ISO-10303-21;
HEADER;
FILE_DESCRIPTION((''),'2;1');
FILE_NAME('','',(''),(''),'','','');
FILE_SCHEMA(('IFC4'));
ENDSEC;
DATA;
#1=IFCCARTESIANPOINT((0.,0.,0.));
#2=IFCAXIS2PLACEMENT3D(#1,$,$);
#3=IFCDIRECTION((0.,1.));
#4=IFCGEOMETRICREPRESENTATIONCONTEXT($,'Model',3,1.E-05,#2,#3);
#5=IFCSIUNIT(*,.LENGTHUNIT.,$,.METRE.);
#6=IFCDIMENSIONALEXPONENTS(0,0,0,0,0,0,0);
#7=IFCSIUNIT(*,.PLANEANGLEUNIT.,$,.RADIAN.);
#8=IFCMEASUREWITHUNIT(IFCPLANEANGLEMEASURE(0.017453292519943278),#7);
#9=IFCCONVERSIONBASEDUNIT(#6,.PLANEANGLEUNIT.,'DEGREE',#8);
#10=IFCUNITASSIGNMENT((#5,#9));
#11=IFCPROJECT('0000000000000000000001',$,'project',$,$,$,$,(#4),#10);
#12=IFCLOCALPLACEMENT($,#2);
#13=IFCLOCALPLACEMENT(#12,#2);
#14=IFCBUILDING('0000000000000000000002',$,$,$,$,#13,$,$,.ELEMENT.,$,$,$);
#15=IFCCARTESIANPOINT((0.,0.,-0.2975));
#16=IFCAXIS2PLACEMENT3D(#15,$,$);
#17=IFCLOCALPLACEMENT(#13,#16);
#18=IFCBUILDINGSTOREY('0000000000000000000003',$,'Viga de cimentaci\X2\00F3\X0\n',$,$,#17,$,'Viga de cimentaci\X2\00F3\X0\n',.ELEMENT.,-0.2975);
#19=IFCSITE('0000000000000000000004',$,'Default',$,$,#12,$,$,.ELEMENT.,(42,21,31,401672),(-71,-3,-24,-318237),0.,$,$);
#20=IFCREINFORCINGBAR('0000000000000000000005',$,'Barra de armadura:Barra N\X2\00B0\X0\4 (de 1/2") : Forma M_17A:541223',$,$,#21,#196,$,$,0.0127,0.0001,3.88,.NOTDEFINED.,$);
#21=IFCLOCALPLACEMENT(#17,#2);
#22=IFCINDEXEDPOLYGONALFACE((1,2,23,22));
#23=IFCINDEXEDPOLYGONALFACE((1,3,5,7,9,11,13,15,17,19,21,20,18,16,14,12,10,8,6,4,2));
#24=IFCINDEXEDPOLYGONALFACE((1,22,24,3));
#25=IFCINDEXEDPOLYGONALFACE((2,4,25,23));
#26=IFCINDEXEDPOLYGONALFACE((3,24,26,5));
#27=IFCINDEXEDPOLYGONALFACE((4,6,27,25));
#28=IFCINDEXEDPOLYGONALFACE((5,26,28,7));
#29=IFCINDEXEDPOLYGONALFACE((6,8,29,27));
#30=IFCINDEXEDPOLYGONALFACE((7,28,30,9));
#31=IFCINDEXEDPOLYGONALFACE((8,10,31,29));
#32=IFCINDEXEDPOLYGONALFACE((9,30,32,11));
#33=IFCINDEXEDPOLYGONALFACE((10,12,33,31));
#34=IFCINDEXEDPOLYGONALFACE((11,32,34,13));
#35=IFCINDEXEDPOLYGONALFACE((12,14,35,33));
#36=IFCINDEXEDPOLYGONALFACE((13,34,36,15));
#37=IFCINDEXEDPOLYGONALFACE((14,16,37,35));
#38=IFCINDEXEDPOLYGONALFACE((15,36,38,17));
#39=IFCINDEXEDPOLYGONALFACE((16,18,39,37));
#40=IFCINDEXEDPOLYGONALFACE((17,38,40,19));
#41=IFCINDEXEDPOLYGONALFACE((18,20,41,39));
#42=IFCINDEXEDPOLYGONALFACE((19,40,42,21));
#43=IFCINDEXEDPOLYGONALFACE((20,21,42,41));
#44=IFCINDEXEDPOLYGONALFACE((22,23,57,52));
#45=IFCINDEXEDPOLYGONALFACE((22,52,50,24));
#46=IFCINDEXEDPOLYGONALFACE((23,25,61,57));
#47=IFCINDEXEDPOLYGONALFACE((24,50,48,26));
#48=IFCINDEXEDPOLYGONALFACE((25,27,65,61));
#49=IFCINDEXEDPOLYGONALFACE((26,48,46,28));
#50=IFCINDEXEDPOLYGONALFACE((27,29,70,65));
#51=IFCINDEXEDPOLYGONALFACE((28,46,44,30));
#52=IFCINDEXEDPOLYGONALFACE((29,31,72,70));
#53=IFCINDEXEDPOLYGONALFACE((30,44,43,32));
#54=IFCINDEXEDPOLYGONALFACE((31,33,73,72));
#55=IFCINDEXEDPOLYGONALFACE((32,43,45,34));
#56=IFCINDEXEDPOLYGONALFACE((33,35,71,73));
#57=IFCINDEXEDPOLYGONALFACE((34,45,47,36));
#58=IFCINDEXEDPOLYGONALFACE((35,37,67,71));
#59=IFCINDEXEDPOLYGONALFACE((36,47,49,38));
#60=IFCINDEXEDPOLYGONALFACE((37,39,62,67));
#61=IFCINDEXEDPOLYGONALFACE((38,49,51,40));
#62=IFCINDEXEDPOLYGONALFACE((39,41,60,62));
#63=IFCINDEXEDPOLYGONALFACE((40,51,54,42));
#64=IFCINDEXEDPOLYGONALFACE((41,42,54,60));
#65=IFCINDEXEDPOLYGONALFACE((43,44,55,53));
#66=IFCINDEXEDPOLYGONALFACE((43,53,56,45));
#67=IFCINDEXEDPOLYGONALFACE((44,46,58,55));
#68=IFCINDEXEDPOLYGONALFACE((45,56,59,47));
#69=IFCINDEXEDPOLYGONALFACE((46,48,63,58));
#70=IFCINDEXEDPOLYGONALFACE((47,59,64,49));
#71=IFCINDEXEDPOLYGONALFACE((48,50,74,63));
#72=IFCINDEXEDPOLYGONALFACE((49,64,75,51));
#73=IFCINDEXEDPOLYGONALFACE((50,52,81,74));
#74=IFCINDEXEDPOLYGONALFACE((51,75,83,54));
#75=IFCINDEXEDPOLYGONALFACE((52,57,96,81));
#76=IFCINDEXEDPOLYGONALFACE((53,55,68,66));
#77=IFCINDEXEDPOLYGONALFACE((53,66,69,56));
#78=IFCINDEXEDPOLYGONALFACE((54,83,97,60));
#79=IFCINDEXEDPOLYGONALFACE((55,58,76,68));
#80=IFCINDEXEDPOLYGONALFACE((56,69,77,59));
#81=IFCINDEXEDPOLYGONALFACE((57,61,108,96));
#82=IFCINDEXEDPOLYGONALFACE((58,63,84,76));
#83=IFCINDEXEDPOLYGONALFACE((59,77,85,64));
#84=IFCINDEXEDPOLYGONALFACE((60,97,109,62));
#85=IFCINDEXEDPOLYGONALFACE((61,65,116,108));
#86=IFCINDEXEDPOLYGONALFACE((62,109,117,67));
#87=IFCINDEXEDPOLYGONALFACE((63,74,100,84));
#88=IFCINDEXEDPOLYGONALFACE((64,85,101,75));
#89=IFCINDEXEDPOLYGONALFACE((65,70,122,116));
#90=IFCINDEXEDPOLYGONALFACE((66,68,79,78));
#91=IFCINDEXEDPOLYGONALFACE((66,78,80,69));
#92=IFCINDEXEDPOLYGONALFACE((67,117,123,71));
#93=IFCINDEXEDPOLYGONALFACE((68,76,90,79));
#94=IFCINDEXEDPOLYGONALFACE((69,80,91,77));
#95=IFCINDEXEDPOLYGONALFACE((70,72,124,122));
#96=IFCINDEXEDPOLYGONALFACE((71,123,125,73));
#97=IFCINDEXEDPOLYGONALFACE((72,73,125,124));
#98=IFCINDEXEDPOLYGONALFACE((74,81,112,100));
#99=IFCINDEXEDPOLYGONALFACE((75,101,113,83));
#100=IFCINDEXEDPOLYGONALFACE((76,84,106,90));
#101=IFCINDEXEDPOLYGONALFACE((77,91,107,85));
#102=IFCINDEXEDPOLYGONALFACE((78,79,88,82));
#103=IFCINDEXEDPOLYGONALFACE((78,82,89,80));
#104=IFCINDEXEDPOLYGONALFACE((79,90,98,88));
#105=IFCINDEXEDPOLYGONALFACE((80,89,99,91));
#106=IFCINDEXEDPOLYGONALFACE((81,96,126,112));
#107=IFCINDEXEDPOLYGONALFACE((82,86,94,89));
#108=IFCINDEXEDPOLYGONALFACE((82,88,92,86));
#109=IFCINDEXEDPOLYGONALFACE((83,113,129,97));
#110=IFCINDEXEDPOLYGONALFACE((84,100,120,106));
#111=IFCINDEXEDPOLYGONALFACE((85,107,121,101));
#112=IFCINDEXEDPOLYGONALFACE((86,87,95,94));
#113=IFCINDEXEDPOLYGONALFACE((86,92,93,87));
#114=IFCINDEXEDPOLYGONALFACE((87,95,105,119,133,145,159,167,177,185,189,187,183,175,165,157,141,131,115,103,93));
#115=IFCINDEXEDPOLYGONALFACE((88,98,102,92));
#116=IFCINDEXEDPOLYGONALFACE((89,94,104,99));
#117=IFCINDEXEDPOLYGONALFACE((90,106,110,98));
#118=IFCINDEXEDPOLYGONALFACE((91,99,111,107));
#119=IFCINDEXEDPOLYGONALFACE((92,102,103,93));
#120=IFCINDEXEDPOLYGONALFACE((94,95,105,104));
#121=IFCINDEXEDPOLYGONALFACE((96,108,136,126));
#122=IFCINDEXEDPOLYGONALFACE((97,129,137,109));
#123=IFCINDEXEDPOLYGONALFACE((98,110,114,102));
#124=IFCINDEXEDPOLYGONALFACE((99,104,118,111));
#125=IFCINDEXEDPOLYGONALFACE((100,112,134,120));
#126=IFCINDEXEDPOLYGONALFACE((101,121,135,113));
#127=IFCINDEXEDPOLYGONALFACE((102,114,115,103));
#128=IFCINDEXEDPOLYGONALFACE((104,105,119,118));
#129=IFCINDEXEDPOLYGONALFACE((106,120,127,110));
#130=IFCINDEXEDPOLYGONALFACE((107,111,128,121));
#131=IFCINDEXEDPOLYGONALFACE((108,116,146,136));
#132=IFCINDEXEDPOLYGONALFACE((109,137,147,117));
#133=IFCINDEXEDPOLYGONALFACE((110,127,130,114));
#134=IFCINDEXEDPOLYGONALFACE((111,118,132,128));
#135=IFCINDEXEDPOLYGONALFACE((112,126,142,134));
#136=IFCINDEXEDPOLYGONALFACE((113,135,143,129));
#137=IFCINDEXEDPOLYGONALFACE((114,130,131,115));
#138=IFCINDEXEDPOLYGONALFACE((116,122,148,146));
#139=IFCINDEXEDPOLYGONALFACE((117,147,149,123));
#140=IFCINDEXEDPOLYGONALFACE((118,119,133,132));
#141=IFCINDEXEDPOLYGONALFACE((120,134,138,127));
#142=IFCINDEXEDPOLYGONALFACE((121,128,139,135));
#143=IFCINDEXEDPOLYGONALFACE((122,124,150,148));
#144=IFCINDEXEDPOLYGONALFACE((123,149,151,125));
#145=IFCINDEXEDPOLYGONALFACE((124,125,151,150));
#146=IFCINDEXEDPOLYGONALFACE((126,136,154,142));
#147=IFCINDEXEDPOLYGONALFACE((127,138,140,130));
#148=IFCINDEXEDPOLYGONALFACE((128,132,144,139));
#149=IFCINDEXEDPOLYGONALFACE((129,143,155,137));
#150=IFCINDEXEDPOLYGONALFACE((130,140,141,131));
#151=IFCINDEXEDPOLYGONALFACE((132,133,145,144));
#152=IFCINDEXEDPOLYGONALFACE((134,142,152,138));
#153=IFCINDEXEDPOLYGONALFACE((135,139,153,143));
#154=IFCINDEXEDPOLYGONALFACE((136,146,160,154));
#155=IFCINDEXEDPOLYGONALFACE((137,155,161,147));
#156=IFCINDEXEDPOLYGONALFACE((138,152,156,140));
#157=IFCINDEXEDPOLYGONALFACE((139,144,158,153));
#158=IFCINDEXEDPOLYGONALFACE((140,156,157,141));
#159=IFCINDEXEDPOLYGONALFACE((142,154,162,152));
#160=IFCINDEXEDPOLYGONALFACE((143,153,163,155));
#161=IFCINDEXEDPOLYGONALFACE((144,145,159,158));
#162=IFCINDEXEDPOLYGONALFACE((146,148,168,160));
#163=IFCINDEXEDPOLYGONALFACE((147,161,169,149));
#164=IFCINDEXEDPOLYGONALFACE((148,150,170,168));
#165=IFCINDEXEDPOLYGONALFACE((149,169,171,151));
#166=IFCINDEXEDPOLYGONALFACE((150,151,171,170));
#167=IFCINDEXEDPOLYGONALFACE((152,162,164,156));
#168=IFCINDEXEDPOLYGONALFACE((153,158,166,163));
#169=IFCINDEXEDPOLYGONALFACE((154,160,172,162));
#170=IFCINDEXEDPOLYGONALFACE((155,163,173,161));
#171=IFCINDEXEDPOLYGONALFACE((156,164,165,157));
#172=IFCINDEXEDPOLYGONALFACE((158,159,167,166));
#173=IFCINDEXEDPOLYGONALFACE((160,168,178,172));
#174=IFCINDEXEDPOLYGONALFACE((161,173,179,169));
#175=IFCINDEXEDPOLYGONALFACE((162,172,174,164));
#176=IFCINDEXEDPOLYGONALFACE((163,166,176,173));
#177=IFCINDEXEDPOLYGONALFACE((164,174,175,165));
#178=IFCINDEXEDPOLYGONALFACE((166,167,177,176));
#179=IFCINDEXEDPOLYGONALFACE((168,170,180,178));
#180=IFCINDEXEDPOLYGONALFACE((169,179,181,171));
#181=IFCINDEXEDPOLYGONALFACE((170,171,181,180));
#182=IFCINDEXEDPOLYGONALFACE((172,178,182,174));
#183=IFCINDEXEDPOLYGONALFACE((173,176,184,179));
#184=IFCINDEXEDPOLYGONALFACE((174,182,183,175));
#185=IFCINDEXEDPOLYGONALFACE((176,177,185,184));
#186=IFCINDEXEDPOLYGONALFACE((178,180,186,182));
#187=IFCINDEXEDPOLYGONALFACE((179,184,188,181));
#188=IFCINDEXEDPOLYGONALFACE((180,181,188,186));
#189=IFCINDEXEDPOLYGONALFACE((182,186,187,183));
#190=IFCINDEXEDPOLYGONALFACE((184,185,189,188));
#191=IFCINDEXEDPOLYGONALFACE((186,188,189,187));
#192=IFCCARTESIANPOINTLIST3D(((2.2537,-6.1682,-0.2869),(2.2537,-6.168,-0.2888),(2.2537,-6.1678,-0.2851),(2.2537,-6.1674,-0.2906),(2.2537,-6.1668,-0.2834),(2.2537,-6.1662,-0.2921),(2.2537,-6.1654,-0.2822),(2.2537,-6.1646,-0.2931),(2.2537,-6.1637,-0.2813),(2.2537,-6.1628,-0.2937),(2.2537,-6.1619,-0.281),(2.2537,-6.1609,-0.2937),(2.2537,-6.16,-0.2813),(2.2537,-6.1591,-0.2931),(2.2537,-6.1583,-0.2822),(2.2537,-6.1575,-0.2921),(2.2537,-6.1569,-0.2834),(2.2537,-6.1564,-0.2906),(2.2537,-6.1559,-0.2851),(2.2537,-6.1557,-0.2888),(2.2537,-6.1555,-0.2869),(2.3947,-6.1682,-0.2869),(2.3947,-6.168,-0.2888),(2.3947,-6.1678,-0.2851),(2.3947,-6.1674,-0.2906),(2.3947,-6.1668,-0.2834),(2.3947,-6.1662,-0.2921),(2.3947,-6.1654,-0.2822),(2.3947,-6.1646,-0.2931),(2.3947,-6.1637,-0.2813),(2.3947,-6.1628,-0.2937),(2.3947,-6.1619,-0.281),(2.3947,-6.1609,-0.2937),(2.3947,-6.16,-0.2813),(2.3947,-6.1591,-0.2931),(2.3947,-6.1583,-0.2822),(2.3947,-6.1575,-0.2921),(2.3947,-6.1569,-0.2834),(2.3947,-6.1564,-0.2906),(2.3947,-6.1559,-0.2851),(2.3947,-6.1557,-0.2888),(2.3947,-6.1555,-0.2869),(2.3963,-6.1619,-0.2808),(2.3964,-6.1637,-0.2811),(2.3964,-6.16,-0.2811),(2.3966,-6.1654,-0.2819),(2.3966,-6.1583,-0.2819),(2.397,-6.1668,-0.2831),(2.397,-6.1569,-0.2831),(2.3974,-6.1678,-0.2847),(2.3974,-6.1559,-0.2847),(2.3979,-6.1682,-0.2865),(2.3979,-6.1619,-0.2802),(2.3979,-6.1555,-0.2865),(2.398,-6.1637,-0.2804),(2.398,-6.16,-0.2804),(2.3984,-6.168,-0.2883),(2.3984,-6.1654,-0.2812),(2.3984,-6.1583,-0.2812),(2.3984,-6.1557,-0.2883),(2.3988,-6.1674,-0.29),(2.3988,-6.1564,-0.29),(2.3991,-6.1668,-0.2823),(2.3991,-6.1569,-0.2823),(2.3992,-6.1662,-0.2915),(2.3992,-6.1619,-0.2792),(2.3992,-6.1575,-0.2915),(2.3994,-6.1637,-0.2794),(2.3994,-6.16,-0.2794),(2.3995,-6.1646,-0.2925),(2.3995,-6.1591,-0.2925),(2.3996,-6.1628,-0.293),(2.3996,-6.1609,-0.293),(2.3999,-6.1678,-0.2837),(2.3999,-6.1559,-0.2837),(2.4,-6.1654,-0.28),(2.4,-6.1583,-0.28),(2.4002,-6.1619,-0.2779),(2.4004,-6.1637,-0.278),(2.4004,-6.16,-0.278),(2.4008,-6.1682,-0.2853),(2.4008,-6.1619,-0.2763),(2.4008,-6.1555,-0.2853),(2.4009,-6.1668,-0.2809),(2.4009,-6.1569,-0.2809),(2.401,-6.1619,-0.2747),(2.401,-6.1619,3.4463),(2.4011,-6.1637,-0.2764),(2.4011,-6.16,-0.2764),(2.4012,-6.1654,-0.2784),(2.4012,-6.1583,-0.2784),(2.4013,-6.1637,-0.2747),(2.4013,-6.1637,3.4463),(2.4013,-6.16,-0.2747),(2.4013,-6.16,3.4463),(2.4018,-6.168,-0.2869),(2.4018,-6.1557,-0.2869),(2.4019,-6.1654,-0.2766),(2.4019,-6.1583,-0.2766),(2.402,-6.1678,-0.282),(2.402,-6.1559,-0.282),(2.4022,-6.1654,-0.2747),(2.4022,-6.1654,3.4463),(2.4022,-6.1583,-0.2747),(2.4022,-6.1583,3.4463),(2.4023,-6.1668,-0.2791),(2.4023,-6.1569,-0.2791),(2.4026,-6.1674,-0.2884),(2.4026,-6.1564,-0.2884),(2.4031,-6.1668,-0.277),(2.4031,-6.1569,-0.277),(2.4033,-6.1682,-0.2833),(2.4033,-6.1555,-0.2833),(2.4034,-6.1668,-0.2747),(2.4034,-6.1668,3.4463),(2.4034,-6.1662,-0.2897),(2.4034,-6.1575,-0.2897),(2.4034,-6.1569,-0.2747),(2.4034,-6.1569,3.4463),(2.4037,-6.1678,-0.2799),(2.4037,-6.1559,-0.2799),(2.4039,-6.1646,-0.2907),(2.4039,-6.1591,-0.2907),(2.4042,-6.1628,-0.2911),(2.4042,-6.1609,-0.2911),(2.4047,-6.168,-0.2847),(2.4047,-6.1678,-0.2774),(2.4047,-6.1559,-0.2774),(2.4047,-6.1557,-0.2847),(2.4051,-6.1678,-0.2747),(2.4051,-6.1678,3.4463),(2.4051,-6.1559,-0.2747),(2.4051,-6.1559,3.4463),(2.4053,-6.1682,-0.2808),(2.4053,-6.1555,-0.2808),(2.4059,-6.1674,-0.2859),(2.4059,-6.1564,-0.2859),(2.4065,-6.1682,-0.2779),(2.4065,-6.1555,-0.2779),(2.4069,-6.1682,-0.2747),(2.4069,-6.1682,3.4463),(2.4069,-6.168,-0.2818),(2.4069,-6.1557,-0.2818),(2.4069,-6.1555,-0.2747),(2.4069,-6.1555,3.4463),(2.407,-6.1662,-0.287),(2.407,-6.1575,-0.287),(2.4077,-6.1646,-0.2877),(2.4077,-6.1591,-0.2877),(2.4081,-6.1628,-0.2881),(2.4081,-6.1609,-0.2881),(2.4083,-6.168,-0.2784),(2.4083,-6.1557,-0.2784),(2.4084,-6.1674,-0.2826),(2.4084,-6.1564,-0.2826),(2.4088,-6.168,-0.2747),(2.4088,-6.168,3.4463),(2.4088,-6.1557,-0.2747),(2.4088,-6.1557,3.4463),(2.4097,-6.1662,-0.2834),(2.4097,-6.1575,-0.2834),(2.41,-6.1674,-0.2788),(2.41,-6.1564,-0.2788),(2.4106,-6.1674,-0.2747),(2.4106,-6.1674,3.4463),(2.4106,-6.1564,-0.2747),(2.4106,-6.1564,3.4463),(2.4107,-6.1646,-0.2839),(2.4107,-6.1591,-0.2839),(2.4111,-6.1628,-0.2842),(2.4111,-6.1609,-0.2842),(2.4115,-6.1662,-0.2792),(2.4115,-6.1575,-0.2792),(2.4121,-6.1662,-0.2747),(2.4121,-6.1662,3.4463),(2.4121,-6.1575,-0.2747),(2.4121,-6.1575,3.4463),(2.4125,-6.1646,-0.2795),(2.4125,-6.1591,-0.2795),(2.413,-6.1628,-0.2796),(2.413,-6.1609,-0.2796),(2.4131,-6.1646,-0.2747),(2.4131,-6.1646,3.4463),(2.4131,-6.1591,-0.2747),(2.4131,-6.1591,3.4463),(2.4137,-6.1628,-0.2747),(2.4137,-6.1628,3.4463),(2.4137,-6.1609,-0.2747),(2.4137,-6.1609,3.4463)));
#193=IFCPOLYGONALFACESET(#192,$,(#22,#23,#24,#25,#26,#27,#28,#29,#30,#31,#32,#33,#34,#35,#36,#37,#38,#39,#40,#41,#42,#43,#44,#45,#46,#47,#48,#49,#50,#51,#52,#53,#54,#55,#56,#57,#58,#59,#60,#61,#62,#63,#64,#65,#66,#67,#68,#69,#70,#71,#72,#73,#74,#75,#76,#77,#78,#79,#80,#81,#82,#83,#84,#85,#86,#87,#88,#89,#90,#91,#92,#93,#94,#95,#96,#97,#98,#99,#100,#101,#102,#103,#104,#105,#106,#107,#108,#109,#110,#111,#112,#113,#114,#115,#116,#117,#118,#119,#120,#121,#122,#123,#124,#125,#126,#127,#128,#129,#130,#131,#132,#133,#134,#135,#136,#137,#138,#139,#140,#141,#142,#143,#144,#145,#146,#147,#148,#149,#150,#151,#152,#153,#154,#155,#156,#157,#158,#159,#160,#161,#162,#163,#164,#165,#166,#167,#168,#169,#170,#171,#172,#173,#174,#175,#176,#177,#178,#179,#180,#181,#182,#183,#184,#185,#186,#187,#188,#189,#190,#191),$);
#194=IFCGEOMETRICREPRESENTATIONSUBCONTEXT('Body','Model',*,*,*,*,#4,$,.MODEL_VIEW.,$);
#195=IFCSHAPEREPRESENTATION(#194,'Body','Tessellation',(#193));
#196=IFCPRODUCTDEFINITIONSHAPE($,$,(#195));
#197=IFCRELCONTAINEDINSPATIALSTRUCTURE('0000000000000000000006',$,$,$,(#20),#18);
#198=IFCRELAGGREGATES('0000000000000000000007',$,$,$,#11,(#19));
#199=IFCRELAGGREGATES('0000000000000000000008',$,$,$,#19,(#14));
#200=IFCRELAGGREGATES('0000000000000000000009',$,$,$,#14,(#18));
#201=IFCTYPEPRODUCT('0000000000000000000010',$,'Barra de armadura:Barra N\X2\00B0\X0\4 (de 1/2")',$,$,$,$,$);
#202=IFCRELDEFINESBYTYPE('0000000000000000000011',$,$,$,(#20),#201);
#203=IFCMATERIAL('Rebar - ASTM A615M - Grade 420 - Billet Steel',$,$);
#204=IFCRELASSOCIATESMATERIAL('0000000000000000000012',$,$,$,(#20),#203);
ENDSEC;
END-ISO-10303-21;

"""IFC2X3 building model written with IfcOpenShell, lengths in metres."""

from ifc_helpers import new_model, entity, si_unit, converted_unit, direction, frame, origin, place, context, subcontext, project, spatial, material, type_object, element, save


model = new_model("IFC2X3")

# Units and contexts
model_context = context("Model", 3, precision=1e-05, world=origin(), true_north=direction((0.0, 1.0)))
body_context = subcontext(model_context, "Body", "Model", "MODEL_VIEW")
ifc_project = project(units=[si_unit("LENGTHUNIT", "METRE"), converted_unit("PLANEANGLEUNIT", "DEGREE", entity("IfcPlaneAngleMeasure", 0.017453292519943278), si_unit("PLANEANGLEUNIT", "RADIAN"), dimensions=[0, 0, 0, 0, 0, 0, 0])], contexts=[model_context])

# Site, building, storey
site_placement = place(None, origin())
site = spatial("IfcSite", under=ifc_project, at=site_placement, Name="Default", CompositionType="ELEMENT", RefLatitude=(42, 21, 31, 401672), RefLongitude=(-71, -3, -24, -318237), RefElevation=0.0)
building_placement = place(site_placement, origin())
building = spatial("IfcBuilding", under=site, at=building_placement, CompositionType="ELEMENT")
storey_placement = place(building_placement, frame((0.0, 0.0, -0.2975)))
storey = spatial("IfcBuildingStorey", under=building, at=storey_placement, Name="Viga de cimentación", LongName="Viga de cimentación", CompositionType="ELEMENT", Elevation=-0.2975)

# Reinforcing bar
ifc_material_1 = material(Name="Rebar - ASTM A615M - Grade 420 - Billet Steel")
type_product_1 = type_object("IfcTypeProduct", Name="Barra de armadura:Barra N°4 (de 1/2\")")
reinforcing_bar_1_placement = place(storey_placement, origin())
element("IfcReinforcingBar", 1, at=reinforcing_bar_1_placement, inside=storey, type_object=type_product_1, material=ifc_material_1, Name="Barra de armadura:Barra N°4 (de 1/2\") : Forma M_17A:541223", BarLength=3.88, BarRole="NOTDEFINED", CrossSectionArea=0.0001, NominalDiameter=0.0127, context=body_context, shape_type="AdvancedSweptSolid", body=[
    entity("IfcSweptDiskSolid", entity("IfcCompositeCurve", [entity("IfcCompositeCurveSegment", "CONTINUOUS", True, entity("IfcPolyline", [entity("IfcCartesianPoint", [2.4074, -6.1619, 3.4463]), entity("IfcCartesianPoint", [2.4074, -6.1619, -0.2747])])), entity("IfcCompositeCurveSegment", "CONTINUOUS", True, entity("IfcTrimmedCurve", entity("IfcCircle", entity("IfcAxis2Placement3D", entity("IfcCartesianPoint", [2.3947, -6.1619, -0.2747]), entity("IfcDirection", [0.0, 1.0, 0.0]), entity("IfcDirection", [0.0, 0.0, -1.0])), 0.0127), [entity("IfcParameterValue", 270.0)], [entity("IfcParameterValue", 360.0)], True, "PARAMETER")), entity("IfcCompositeCurveSegment", "CONTINUOUS", True, entity("IfcPolyline", [entity("IfcCartesianPoint", [2.3947, -6.1619, -0.2874]), entity("IfcCartesianPoint", [2.2537, -6.1619, -0.2874])]))], False), 0.0063, None, 0.0, 92.0),
])

save(model, "model.ifc")
